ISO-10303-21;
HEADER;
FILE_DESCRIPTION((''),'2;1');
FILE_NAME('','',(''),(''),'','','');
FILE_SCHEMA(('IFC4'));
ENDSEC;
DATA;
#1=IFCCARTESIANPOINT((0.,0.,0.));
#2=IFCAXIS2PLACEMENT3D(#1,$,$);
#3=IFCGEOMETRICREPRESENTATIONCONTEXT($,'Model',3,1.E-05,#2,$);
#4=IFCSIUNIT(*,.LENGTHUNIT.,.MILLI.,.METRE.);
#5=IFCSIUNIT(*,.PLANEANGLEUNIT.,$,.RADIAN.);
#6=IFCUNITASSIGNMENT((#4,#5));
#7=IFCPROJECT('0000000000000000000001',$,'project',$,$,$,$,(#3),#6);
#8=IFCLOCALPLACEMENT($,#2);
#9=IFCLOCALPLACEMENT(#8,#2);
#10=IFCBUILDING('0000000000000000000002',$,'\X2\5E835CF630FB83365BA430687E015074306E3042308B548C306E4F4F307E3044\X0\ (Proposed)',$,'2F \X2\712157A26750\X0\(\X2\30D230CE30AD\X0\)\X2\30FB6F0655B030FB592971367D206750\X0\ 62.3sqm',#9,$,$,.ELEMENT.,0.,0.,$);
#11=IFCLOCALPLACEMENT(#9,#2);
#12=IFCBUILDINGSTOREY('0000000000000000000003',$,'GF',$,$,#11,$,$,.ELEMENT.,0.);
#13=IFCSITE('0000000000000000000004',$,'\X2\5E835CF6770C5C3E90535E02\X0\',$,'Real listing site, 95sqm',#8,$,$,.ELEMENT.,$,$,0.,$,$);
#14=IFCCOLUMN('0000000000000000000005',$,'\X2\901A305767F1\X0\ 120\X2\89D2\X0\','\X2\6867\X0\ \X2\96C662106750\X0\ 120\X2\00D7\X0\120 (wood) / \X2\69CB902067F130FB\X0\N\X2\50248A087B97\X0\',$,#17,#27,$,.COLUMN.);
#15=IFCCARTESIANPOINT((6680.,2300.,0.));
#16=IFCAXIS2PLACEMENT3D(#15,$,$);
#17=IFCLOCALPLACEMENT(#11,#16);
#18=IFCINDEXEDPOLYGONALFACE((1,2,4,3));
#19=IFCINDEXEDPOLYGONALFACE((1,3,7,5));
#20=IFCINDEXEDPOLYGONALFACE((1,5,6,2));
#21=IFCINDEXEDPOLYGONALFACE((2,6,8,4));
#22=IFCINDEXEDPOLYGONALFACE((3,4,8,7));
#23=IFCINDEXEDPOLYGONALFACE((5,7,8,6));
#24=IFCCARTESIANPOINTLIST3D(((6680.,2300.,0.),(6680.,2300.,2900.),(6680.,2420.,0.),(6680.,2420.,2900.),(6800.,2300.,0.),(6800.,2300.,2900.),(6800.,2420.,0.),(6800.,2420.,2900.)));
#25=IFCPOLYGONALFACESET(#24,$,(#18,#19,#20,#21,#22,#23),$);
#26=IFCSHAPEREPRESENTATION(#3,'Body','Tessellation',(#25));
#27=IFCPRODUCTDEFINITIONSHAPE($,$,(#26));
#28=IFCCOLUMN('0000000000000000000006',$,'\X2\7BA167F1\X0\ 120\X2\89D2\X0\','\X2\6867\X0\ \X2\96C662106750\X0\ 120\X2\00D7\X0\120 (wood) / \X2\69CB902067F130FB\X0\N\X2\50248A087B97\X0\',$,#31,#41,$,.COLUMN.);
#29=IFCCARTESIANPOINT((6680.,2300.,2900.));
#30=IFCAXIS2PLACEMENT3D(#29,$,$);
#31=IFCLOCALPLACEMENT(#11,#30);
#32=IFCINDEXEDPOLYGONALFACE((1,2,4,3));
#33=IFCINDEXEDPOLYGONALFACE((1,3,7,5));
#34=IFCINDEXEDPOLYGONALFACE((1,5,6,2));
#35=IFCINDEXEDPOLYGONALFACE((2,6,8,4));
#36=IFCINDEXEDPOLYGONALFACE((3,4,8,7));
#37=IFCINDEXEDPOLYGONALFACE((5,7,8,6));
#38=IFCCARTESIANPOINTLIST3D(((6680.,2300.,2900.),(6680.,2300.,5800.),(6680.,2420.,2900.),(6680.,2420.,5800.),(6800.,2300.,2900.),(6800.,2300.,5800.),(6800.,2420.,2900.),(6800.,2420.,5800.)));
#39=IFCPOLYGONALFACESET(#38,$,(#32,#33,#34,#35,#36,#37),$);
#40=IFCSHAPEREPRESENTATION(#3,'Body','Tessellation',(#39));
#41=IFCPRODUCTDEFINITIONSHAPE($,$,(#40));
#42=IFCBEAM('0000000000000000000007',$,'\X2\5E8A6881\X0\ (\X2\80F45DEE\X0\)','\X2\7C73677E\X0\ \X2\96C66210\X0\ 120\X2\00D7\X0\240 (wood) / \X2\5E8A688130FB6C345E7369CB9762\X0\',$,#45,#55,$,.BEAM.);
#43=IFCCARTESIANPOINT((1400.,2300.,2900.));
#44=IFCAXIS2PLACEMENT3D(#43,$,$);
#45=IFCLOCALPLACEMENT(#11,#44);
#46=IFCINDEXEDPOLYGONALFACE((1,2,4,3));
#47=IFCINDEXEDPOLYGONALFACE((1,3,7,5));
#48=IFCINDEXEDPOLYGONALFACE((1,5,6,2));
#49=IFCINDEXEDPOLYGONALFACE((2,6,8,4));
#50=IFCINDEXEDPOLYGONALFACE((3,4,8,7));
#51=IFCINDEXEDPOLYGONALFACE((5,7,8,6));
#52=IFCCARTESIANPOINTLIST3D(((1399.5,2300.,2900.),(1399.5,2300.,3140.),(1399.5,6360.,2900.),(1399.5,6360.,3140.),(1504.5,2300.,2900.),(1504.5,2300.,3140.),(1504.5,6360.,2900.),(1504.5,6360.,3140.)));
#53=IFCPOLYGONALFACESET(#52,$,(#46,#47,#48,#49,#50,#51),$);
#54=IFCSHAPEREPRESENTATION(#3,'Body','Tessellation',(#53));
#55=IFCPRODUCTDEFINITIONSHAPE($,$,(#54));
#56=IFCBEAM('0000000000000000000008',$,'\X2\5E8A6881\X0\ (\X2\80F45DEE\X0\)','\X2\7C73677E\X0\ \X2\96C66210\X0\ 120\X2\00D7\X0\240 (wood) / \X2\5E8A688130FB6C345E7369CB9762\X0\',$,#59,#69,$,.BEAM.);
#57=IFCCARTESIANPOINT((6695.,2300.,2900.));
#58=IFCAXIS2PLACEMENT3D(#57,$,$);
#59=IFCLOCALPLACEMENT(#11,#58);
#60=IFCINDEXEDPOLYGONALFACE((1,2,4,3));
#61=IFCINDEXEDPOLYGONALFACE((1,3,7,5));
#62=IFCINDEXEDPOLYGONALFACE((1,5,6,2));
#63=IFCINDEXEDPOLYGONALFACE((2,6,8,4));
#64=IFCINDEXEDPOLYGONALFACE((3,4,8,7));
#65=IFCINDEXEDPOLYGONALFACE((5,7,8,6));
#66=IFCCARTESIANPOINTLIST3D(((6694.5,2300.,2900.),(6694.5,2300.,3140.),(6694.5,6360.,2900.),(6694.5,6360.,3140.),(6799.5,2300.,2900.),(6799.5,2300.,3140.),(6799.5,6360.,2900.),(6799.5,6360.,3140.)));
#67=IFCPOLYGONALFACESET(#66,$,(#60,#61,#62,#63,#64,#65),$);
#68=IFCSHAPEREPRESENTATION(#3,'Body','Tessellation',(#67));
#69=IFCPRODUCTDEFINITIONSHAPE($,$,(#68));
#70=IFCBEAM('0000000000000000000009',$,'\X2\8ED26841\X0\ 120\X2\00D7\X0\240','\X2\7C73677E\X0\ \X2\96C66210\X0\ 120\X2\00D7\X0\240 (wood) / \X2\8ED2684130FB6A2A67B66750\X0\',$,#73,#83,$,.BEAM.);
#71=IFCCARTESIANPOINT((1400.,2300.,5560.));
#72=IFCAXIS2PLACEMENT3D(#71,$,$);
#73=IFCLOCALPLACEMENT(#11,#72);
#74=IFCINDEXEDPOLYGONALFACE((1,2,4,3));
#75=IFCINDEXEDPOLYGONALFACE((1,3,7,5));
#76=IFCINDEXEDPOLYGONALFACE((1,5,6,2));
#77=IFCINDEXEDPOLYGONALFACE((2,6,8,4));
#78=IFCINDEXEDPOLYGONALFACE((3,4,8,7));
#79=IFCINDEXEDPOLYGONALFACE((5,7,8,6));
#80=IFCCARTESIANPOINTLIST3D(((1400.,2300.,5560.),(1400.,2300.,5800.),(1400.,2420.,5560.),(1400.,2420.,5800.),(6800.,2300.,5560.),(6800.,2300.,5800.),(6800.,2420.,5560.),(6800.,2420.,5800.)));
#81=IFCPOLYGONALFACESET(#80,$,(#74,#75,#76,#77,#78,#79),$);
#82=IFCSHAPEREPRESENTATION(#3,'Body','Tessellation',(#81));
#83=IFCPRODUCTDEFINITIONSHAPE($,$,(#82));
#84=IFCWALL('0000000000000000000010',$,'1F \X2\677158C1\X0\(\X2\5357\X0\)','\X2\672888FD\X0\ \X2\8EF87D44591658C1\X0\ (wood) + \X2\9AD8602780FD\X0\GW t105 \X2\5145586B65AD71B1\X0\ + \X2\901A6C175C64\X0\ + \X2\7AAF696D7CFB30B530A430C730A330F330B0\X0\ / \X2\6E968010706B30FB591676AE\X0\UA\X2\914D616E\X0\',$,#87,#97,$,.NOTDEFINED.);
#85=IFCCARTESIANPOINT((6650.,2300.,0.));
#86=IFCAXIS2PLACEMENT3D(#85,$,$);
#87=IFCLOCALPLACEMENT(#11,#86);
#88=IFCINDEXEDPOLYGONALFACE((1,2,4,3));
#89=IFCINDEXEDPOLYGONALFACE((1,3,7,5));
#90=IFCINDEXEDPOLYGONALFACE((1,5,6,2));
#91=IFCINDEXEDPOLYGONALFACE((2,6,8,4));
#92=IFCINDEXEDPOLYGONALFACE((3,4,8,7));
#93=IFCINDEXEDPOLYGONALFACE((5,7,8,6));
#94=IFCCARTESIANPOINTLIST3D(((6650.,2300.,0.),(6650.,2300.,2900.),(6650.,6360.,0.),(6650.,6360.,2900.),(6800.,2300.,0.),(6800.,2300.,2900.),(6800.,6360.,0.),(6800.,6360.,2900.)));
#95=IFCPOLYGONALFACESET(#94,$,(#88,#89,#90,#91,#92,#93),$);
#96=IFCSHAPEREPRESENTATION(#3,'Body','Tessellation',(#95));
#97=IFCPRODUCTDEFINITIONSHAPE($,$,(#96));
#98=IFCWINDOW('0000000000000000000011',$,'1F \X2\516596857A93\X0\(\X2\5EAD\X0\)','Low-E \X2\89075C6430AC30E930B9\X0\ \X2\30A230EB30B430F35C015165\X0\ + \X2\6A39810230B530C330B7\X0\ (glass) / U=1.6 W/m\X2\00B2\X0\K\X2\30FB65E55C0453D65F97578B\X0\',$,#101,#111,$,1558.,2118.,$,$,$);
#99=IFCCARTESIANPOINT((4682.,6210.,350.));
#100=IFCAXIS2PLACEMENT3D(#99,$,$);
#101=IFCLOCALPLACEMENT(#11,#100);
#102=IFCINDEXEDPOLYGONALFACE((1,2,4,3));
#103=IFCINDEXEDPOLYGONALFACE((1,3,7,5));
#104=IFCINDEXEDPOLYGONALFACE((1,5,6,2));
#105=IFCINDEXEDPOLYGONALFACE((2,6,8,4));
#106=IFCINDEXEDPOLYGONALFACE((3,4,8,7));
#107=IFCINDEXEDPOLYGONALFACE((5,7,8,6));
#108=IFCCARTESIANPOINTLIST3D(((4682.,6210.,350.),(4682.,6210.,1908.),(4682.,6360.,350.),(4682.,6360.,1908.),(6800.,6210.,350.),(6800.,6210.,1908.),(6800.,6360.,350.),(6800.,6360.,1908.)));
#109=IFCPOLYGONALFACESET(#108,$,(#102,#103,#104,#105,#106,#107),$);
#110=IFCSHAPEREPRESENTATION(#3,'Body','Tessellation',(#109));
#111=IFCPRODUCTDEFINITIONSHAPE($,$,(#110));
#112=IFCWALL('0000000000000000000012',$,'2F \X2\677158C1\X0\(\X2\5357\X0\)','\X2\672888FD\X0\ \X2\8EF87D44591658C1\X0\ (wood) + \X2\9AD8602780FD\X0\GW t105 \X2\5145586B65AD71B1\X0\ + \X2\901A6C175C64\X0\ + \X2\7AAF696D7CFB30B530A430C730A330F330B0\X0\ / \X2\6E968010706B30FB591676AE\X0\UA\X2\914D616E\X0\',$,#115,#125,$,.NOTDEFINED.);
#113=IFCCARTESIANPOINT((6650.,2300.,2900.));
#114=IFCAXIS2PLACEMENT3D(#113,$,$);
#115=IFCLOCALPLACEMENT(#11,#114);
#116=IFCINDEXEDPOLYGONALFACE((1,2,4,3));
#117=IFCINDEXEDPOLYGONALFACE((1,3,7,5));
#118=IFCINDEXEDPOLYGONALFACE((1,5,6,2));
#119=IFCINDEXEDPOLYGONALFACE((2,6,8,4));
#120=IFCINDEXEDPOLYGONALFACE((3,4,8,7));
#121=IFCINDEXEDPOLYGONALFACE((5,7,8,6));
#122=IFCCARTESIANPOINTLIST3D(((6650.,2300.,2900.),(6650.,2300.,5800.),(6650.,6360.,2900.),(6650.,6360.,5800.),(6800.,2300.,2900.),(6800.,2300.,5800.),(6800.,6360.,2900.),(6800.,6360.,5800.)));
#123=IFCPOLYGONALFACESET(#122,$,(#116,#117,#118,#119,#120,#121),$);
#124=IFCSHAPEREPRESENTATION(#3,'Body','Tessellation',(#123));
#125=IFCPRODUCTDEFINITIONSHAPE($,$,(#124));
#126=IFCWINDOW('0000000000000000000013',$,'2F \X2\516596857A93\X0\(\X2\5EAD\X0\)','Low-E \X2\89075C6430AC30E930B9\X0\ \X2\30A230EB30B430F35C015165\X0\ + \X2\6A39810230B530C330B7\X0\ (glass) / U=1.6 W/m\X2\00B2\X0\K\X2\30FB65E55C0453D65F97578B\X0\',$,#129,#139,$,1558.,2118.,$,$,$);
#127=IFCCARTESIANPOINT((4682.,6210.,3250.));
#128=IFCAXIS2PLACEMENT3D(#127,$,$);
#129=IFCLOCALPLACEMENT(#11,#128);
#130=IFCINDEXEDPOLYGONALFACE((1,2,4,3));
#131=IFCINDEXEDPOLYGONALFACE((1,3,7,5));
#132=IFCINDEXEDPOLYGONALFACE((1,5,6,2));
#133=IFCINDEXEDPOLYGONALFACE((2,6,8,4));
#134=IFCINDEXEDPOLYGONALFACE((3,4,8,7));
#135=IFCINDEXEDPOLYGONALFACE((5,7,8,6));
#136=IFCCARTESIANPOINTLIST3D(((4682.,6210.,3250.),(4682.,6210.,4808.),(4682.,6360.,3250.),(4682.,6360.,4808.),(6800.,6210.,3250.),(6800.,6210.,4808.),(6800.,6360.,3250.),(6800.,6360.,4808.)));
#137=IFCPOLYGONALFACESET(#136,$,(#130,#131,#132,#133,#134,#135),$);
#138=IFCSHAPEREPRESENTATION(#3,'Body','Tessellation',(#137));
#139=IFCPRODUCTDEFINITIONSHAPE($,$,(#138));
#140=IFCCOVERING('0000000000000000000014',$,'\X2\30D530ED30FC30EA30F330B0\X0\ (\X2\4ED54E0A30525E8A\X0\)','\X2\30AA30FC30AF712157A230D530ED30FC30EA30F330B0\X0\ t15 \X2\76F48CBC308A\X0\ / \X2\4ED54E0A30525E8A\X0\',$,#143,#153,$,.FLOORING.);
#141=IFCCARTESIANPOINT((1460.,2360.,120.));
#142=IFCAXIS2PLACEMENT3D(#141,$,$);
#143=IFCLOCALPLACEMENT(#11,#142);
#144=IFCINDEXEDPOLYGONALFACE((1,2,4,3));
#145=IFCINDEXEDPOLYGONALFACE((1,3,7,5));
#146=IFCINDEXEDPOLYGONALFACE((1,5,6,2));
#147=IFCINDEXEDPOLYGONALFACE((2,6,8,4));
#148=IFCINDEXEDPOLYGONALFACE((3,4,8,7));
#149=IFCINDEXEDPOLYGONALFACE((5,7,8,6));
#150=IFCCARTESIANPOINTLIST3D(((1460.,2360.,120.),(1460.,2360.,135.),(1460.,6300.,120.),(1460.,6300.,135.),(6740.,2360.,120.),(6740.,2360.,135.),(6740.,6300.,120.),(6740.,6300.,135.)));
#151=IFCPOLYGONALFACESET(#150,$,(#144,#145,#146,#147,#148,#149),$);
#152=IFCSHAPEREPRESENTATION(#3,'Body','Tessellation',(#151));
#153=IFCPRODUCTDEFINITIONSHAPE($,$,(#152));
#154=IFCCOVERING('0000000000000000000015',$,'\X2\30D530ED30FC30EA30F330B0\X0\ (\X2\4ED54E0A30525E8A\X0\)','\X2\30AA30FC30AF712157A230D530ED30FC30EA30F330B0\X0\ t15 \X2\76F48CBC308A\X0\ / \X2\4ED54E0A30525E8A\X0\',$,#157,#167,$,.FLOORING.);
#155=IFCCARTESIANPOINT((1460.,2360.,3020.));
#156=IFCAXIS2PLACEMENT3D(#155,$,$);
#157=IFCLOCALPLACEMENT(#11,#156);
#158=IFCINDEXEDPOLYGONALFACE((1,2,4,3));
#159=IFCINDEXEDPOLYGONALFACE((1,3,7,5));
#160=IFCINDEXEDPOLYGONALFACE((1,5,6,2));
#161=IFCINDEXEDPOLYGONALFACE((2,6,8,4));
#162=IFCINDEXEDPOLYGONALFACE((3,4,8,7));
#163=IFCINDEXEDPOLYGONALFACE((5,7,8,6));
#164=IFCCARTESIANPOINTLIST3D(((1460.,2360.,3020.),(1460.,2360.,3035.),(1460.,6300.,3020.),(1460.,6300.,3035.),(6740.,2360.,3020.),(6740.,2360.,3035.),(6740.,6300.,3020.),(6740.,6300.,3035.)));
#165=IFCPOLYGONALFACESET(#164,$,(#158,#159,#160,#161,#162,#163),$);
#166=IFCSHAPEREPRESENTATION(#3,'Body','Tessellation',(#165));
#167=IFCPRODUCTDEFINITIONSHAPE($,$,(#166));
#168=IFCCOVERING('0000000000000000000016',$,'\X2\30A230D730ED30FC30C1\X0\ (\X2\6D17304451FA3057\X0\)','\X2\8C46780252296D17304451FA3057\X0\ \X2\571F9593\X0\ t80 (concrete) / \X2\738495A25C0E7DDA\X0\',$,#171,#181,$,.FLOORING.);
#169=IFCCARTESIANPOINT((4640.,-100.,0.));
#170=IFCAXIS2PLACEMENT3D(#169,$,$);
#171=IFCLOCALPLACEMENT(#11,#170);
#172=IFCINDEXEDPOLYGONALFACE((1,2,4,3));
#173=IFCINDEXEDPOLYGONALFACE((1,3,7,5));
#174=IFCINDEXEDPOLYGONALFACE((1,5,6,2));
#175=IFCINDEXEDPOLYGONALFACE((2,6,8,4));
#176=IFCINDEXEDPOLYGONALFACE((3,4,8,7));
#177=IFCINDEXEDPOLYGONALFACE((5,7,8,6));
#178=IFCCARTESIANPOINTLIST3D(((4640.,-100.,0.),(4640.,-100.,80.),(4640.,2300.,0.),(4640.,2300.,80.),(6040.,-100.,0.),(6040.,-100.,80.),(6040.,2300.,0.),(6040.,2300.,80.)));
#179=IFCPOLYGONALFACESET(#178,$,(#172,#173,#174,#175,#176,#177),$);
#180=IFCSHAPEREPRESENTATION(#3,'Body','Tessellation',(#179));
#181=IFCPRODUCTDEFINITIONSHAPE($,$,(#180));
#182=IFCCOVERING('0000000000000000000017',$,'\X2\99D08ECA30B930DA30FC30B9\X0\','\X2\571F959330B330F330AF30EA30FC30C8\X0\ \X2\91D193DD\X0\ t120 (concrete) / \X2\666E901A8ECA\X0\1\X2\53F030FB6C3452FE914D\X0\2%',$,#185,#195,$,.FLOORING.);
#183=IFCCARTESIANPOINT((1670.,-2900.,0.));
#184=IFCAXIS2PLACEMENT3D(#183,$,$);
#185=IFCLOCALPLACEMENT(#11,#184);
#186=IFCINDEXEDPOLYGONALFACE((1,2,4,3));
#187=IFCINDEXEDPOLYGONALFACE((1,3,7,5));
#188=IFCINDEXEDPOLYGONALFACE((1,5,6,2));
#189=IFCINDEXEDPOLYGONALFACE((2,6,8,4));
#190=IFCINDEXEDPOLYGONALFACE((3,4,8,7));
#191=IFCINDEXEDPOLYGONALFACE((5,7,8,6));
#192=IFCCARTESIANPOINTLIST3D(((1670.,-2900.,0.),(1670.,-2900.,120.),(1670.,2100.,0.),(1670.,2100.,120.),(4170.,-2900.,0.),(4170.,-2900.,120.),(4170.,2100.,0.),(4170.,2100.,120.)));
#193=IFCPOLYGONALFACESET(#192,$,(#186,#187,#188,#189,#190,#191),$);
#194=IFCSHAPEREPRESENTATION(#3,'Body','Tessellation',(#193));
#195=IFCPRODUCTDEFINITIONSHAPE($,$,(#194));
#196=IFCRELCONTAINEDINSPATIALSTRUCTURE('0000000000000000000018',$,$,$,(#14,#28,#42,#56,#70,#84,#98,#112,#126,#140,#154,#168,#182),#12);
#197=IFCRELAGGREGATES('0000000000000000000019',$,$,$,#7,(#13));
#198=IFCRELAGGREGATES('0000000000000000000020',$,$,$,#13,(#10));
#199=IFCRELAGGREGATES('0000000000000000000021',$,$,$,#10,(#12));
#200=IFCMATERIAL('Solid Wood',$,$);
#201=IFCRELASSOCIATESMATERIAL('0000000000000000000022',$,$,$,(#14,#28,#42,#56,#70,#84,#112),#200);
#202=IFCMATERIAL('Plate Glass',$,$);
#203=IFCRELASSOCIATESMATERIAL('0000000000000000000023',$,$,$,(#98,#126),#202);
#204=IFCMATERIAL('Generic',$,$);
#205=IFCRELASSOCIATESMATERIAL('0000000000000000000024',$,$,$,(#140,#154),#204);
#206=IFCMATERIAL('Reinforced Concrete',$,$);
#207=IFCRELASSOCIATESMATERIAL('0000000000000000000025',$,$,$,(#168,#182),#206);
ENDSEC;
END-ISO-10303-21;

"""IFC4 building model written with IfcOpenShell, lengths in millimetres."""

from ifc_helpers import new_model, si_unit, frame, frame_2d, origin, place, context, project, spatial, rectangle, extrude, material, element, fill, save


model = new_model("IFC4")

# Units and contexts
model_context = context("Model", 3, precision=1e-05, world=origin())
ifc_project = project(units=[si_unit("LENGTHUNIT", "METRE", prefix="MILLI"), si_unit("PLANEANGLEUNIT", "RADIAN")], contexts=[model_context])

# Site, building, storey
site_placement = place(None, origin())
site = spatial("IfcSite", under=ifc_project, at=site_placement, Name="広島県尾道市", ObjectType="Real listing site, 95sqm", CompositionType="ELEMENT", RefElevation=0.0)
building_placement = place(site_placement, origin())
building = spatial("IfcBuilding", under=site, at=building_placement, Name="広島・茶室と縁側のある和の住まい (Proposed)", ObjectType="2F 無垢材(ヒノキ)・漆喰・天然素材 62.3sqm", CompositionType="ELEMENT", ElevationOfRefHeight=0.0, ElevationOfTerrain=0.0)
storey_placement = place(building_placement, origin())
storey = spatial("IfcBuildingStorey", under=building, at=storey_placement, Name="GF", CompositionType="ELEMENT", Elevation=0.0)

# Columns
ifc_material_1 = material(Name="Solid Wood")
column_1_placement = place(storey_placement, frame((6680.0, 2300.0, 0.0)))
element("IfcColumn", 1, at=column_1_placement, inside=storey, material=ifc_material_1, Name="通し柱 120角", Description="桧 集成材 120×120 (wood) / 構造柱・N値計算", PredefinedType="COLUMN", context=model_context, shape_type="SweptSolid", body=[
    extrude(rectangle(XDim=120.0, YDim=120.0, at=frame_2d((60.0, 60.0))), frame((6680.0, 2300.0, 0.0)), (0.0, 0.0, 1.0), 2900.0),
])
column_2_placement = place(storey_placement, frame((6680.0, 2300.0, 2900.0)))
element("IfcColumn", 2, at=column_2_placement, inside=storey, material=ifc_material_1, Name="管柱 120角", Description="桧 集成材 120×120 (wood) / 構造柱・N値計算", PredefinedType="COLUMN", context=model_context, shape_type="SweptSolid", body=[
    extrude(rectangle(XDim=120.0, YDim=120.0, at=frame_2d((60.0, 60.0))), frame((6680.0, 2300.0, 2900.0)), (0.0, 0.0, 1.0), 2900.0),
])

# Beams
beam_1_placement = place(storey_placement, frame((1400.0, 2300.0, 2900.0)))
element("IfcBeam", 3, at=beam_1_placement, inside=storey, material=ifc_material_1, Name="床梁 (胴差)", Description="米松 集成 120×240 (wood) / 床梁・水平構面", PredefinedType="BEAM", context=model_context, shape_type="SweptSolid", body=[
    extrude(rectangle(XDim=105.0, YDim=4060.0, at=frame_2d((52.0, 2030.0))), frame((1400.0, 2300.0, 2900.0)), (0.0, 0.0, 1.0), 240.0),
])
beam_2_placement = place(storey_placement, frame((6695.0, 2300.0, 2900.0)))
element("IfcBeam", 4, at=beam_2_placement, inside=storey, material=ifc_material_1, Name="床梁 (胴差)", Description="米松 集成 120×240 (wood) / 床梁・水平構面", PredefinedType="BEAM", context=model_context, shape_type="SweptSolid", body=[
    extrude(rectangle(XDim=105.0, YDim=4060.0, at=frame_2d((52.0, 2030.0))), frame((6695.0, 2300.0, 2900.0)), (0.0, 0.0, 1.0), 240.0),
])
beam_3_placement = place(storey_placement, frame((1400.0, 2300.0, 5560.0)))
element("IfcBeam", 5, at=beam_3_placement, inside=storey, material=ifc_material_1, Name="軒桁 120×240", Description="米松 集成 120×240 (wood) / 軒桁・横架材", PredefinedType="BEAM", context=model_context, shape_type="SweptSolid", body=[
    extrude(rectangle(XDim=5400.0, YDim=120.0, at=frame_2d((2700.0, 60.0))), frame((1400.0, 2300.0, 5560.0)), (0.0, 0.0, 1.0), 240.0),
])

# Wall, opening, window
wall_1_placement = place(storey_placement, frame((6650.0, 2300.0, 0.0)))
wall_1 = element("IfcWall", 6, at=wall_1_placement, inside=storey, material=ifc_material_1, Name="1F 東壁(南)", Description="木製 軸組外壁 (wood) + 高性能GW t105 充填断熱 + 通気層 + 窯業系サイディング / 準耐火・外皮UA配慮", PredefinedType="NOTDEFINED", context=model_context, shape_type="SweptSolid", body=[
    extrude(rectangle(XDim=150.0, YDim=4060.0, at=frame_2d((75.0, 2030.0))), frame((6650.0, 2300.0, 0.0)), (0.0, 0.0, 1.0), 2900.0),
])
opening_1_placement = place(storey_placement, frame((4682.0, 6210.0, 350.0)))
opening_1 = element("IfcOpeningElement", 7, at=opening_1_placement, cuts=wall_1, PredefinedType="NOTDEFINED", context=model_context, shape_type="SweptSolid", body=[
    extrude(rectangle(XDim=2118.0, YDim=150.0, at=frame_2d((1059.0, 75.0))), frame((4682.0, 6210.0, 350.0)), (0.0, 0.0, 1.0), 1558.0),
])
ifc_material_2 = material(Name="Plate Glass")
window_1_placement = place(storey_placement, frame((4682.0, 6210.0, 350.0)))
window_1 = element("IfcWindow", 8, at=window_1_placement, inside=storey, material=ifc_material_2, Name="1F 入隅窓(庭)", Description="Low-E 複層ガラス アルゴン封入 + 樹脂サッシ (glass) / U=1.6 W/m²K・日射取得型", OverallHeight=1558.0, OverallWidth=2118.0, context=model_context, shape_type="SweptSolid", body=[
    extrude(rectangle(XDim=2118.0, YDim=150.0, at=frame_2d((1059.0, 75.0))), frame((4682.0, 6210.0, 350.0)), (0.0, 0.0, 1.0), 1558.0),
])
fill(opening_1, window_1)

# Wall, opening, window
wall_2_placement = place(storey_placement, frame((6650.0, 2300.0, 2900.0)))
wall_2 = element("IfcWall", 9, at=wall_2_placement, inside=storey, material=ifc_material_1, Name="2F 東壁(南)", Description="木製 軸組外壁 (wood) + 高性能GW t105 充填断熱 + 通気層 + 窯業系サイディング / 準耐火・外皮UA配慮", PredefinedType="NOTDEFINED", context=model_context, shape_type="SweptSolid", body=[
    extrude(rectangle(XDim=150.0, YDim=4060.0, at=frame_2d((75.0, 2030.0))), frame((6650.0, 2300.0, 2900.0)), (0.0, 0.0, 1.0), 2900.0),
])
opening_2_placement = place(storey_placement, frame((4682.0, 6210.0, 3250.0)))
opening_2 = element("IfcOpeningElement", 10, at=opening_2_placement, cuts=wall_2, PredefinedType="NOTDEFINED", context=model_context, shape_type="SweptSolid", body=[
    extrude(rectangle(XDim=2118.0, YDim=150.0, at=frame_2d((1059.0, 75.0))), frame((4682.0, 6210.0, 3250.0)), (0.0, 0.0, 1.0), 1558.0),
])
window_2_placement = place(storey_placement, frame((4682.0, 6210.0, 3250.0)))
window_2 = element("IfcWindow", 11, at=window_2_placement, inside=storey, material=ifc_material_2, Name="2F 入隅窓(庭)", Description="Low-E 複層ガラス アルゴン封入 + 樹脂サッシ (glass) / U=1.6 W/m²K・日射取得型", OverallHeight=1558.0, OverallWidth=2118.0, context=model_context, shape_type="SweptSolid", body=[
    extrude(rectangle(XDim=2118.0, YDim=150.0, at=frame_2d((1059.0, 75.0))), frame((4682.0, 6210.0, 3250.0)), (0.0, 0.0, 1.0), 1558.0),
])
fill(opening_2, window_2)

# Coverings
ifc_material_3 = material(Name="Generic")
covering_1_placement = place(storey_placement, frame((1460.0, 2360.0, 120.0)))
element("IfcCovering", 12, at=covering_1_placement, inside=storey, material=ifc_material_3, Name="フローリング (仕上げ床)", Description="オーク無垢フローリング t15 直貼り / 仕上げ床", PredefinedType="FLOORING", context=model_context, shape_type="SweptSolid", body=[
    extrude(rectangle(XDim=5280.0, YDim=3940.0, at=frame_2d((2640.0, 1970.0))), frame((1460.0, 2360.0, 120.0)), (0.0, 0.0, 1.0), 15.0),
])
covering_2_placement = place(storey_placement, frame((1460.0, 2360.0, 3020.0)))
element("IfcCovering", 13, at=covering_2_placement, inside=storey, material=ifc_material_3, Name="フローリング (仕上げ床)", Description="オーク無垢フローリング t15 直貼り / 仕上げ床", PredefinedType="FLOORING", context=model_context, shape_type="SweptSolid", body=[
    extrude(rectangle(XDim=5280.0, YDim=3940.0, at=frame_2d((2640.0, 1970.0))), frame((1460.0, 2360.0, 3020.0)), (0.0, 0.0, 1.0), 15.0),
])
ifc_material_4 = material(Name="Reinforced Concrete")
covering_3_placement = place(storey_placement, frame((4640.0, -100.0, 0.0)))
element("IfcCovering", 14, at=covering_3_placement, inside=storey, material=ifc_material_4, Name="アプローチ (洗い出し)", Description="豆砂利洗い出し 土間 t80 (concrete) / 玄関導線", PredefinedType="FLOORING", context=model_context, shape_type="SweptSolid", body=[
    extrude(rectangle(XDim=1400.0, YDim=2400.0, at=frame_2d((700.0, 1200.0))), frame((4640.0, -100.0, 0.0)), (0.0, 0.0, 1.0), 80.0),
])
covering_4_placement = place(storey_placement, frame((1670.0, -2900.0, 0.0)))
element("IfcCovering", 15, at=covering_4_placement, inside=storey, material=ifc_material_4, Name="駐車スペース", Description="土間コンクリート 金鏝 t120 (concrete) / 普通車1台・水勾配2%", PredefinedType="FLOORING", context=model_context, shape_type="SweptSolid", body=[
    extrude(rectangle(XDim=2500.0, YDim=5000.0, at=frame_2d((1250.0, 2500.0))), frame((1670.0, -2900.0, 0.0)), (0.0, 0.0, 1.0), 120.0),
])

save(model, "model.ifc")
